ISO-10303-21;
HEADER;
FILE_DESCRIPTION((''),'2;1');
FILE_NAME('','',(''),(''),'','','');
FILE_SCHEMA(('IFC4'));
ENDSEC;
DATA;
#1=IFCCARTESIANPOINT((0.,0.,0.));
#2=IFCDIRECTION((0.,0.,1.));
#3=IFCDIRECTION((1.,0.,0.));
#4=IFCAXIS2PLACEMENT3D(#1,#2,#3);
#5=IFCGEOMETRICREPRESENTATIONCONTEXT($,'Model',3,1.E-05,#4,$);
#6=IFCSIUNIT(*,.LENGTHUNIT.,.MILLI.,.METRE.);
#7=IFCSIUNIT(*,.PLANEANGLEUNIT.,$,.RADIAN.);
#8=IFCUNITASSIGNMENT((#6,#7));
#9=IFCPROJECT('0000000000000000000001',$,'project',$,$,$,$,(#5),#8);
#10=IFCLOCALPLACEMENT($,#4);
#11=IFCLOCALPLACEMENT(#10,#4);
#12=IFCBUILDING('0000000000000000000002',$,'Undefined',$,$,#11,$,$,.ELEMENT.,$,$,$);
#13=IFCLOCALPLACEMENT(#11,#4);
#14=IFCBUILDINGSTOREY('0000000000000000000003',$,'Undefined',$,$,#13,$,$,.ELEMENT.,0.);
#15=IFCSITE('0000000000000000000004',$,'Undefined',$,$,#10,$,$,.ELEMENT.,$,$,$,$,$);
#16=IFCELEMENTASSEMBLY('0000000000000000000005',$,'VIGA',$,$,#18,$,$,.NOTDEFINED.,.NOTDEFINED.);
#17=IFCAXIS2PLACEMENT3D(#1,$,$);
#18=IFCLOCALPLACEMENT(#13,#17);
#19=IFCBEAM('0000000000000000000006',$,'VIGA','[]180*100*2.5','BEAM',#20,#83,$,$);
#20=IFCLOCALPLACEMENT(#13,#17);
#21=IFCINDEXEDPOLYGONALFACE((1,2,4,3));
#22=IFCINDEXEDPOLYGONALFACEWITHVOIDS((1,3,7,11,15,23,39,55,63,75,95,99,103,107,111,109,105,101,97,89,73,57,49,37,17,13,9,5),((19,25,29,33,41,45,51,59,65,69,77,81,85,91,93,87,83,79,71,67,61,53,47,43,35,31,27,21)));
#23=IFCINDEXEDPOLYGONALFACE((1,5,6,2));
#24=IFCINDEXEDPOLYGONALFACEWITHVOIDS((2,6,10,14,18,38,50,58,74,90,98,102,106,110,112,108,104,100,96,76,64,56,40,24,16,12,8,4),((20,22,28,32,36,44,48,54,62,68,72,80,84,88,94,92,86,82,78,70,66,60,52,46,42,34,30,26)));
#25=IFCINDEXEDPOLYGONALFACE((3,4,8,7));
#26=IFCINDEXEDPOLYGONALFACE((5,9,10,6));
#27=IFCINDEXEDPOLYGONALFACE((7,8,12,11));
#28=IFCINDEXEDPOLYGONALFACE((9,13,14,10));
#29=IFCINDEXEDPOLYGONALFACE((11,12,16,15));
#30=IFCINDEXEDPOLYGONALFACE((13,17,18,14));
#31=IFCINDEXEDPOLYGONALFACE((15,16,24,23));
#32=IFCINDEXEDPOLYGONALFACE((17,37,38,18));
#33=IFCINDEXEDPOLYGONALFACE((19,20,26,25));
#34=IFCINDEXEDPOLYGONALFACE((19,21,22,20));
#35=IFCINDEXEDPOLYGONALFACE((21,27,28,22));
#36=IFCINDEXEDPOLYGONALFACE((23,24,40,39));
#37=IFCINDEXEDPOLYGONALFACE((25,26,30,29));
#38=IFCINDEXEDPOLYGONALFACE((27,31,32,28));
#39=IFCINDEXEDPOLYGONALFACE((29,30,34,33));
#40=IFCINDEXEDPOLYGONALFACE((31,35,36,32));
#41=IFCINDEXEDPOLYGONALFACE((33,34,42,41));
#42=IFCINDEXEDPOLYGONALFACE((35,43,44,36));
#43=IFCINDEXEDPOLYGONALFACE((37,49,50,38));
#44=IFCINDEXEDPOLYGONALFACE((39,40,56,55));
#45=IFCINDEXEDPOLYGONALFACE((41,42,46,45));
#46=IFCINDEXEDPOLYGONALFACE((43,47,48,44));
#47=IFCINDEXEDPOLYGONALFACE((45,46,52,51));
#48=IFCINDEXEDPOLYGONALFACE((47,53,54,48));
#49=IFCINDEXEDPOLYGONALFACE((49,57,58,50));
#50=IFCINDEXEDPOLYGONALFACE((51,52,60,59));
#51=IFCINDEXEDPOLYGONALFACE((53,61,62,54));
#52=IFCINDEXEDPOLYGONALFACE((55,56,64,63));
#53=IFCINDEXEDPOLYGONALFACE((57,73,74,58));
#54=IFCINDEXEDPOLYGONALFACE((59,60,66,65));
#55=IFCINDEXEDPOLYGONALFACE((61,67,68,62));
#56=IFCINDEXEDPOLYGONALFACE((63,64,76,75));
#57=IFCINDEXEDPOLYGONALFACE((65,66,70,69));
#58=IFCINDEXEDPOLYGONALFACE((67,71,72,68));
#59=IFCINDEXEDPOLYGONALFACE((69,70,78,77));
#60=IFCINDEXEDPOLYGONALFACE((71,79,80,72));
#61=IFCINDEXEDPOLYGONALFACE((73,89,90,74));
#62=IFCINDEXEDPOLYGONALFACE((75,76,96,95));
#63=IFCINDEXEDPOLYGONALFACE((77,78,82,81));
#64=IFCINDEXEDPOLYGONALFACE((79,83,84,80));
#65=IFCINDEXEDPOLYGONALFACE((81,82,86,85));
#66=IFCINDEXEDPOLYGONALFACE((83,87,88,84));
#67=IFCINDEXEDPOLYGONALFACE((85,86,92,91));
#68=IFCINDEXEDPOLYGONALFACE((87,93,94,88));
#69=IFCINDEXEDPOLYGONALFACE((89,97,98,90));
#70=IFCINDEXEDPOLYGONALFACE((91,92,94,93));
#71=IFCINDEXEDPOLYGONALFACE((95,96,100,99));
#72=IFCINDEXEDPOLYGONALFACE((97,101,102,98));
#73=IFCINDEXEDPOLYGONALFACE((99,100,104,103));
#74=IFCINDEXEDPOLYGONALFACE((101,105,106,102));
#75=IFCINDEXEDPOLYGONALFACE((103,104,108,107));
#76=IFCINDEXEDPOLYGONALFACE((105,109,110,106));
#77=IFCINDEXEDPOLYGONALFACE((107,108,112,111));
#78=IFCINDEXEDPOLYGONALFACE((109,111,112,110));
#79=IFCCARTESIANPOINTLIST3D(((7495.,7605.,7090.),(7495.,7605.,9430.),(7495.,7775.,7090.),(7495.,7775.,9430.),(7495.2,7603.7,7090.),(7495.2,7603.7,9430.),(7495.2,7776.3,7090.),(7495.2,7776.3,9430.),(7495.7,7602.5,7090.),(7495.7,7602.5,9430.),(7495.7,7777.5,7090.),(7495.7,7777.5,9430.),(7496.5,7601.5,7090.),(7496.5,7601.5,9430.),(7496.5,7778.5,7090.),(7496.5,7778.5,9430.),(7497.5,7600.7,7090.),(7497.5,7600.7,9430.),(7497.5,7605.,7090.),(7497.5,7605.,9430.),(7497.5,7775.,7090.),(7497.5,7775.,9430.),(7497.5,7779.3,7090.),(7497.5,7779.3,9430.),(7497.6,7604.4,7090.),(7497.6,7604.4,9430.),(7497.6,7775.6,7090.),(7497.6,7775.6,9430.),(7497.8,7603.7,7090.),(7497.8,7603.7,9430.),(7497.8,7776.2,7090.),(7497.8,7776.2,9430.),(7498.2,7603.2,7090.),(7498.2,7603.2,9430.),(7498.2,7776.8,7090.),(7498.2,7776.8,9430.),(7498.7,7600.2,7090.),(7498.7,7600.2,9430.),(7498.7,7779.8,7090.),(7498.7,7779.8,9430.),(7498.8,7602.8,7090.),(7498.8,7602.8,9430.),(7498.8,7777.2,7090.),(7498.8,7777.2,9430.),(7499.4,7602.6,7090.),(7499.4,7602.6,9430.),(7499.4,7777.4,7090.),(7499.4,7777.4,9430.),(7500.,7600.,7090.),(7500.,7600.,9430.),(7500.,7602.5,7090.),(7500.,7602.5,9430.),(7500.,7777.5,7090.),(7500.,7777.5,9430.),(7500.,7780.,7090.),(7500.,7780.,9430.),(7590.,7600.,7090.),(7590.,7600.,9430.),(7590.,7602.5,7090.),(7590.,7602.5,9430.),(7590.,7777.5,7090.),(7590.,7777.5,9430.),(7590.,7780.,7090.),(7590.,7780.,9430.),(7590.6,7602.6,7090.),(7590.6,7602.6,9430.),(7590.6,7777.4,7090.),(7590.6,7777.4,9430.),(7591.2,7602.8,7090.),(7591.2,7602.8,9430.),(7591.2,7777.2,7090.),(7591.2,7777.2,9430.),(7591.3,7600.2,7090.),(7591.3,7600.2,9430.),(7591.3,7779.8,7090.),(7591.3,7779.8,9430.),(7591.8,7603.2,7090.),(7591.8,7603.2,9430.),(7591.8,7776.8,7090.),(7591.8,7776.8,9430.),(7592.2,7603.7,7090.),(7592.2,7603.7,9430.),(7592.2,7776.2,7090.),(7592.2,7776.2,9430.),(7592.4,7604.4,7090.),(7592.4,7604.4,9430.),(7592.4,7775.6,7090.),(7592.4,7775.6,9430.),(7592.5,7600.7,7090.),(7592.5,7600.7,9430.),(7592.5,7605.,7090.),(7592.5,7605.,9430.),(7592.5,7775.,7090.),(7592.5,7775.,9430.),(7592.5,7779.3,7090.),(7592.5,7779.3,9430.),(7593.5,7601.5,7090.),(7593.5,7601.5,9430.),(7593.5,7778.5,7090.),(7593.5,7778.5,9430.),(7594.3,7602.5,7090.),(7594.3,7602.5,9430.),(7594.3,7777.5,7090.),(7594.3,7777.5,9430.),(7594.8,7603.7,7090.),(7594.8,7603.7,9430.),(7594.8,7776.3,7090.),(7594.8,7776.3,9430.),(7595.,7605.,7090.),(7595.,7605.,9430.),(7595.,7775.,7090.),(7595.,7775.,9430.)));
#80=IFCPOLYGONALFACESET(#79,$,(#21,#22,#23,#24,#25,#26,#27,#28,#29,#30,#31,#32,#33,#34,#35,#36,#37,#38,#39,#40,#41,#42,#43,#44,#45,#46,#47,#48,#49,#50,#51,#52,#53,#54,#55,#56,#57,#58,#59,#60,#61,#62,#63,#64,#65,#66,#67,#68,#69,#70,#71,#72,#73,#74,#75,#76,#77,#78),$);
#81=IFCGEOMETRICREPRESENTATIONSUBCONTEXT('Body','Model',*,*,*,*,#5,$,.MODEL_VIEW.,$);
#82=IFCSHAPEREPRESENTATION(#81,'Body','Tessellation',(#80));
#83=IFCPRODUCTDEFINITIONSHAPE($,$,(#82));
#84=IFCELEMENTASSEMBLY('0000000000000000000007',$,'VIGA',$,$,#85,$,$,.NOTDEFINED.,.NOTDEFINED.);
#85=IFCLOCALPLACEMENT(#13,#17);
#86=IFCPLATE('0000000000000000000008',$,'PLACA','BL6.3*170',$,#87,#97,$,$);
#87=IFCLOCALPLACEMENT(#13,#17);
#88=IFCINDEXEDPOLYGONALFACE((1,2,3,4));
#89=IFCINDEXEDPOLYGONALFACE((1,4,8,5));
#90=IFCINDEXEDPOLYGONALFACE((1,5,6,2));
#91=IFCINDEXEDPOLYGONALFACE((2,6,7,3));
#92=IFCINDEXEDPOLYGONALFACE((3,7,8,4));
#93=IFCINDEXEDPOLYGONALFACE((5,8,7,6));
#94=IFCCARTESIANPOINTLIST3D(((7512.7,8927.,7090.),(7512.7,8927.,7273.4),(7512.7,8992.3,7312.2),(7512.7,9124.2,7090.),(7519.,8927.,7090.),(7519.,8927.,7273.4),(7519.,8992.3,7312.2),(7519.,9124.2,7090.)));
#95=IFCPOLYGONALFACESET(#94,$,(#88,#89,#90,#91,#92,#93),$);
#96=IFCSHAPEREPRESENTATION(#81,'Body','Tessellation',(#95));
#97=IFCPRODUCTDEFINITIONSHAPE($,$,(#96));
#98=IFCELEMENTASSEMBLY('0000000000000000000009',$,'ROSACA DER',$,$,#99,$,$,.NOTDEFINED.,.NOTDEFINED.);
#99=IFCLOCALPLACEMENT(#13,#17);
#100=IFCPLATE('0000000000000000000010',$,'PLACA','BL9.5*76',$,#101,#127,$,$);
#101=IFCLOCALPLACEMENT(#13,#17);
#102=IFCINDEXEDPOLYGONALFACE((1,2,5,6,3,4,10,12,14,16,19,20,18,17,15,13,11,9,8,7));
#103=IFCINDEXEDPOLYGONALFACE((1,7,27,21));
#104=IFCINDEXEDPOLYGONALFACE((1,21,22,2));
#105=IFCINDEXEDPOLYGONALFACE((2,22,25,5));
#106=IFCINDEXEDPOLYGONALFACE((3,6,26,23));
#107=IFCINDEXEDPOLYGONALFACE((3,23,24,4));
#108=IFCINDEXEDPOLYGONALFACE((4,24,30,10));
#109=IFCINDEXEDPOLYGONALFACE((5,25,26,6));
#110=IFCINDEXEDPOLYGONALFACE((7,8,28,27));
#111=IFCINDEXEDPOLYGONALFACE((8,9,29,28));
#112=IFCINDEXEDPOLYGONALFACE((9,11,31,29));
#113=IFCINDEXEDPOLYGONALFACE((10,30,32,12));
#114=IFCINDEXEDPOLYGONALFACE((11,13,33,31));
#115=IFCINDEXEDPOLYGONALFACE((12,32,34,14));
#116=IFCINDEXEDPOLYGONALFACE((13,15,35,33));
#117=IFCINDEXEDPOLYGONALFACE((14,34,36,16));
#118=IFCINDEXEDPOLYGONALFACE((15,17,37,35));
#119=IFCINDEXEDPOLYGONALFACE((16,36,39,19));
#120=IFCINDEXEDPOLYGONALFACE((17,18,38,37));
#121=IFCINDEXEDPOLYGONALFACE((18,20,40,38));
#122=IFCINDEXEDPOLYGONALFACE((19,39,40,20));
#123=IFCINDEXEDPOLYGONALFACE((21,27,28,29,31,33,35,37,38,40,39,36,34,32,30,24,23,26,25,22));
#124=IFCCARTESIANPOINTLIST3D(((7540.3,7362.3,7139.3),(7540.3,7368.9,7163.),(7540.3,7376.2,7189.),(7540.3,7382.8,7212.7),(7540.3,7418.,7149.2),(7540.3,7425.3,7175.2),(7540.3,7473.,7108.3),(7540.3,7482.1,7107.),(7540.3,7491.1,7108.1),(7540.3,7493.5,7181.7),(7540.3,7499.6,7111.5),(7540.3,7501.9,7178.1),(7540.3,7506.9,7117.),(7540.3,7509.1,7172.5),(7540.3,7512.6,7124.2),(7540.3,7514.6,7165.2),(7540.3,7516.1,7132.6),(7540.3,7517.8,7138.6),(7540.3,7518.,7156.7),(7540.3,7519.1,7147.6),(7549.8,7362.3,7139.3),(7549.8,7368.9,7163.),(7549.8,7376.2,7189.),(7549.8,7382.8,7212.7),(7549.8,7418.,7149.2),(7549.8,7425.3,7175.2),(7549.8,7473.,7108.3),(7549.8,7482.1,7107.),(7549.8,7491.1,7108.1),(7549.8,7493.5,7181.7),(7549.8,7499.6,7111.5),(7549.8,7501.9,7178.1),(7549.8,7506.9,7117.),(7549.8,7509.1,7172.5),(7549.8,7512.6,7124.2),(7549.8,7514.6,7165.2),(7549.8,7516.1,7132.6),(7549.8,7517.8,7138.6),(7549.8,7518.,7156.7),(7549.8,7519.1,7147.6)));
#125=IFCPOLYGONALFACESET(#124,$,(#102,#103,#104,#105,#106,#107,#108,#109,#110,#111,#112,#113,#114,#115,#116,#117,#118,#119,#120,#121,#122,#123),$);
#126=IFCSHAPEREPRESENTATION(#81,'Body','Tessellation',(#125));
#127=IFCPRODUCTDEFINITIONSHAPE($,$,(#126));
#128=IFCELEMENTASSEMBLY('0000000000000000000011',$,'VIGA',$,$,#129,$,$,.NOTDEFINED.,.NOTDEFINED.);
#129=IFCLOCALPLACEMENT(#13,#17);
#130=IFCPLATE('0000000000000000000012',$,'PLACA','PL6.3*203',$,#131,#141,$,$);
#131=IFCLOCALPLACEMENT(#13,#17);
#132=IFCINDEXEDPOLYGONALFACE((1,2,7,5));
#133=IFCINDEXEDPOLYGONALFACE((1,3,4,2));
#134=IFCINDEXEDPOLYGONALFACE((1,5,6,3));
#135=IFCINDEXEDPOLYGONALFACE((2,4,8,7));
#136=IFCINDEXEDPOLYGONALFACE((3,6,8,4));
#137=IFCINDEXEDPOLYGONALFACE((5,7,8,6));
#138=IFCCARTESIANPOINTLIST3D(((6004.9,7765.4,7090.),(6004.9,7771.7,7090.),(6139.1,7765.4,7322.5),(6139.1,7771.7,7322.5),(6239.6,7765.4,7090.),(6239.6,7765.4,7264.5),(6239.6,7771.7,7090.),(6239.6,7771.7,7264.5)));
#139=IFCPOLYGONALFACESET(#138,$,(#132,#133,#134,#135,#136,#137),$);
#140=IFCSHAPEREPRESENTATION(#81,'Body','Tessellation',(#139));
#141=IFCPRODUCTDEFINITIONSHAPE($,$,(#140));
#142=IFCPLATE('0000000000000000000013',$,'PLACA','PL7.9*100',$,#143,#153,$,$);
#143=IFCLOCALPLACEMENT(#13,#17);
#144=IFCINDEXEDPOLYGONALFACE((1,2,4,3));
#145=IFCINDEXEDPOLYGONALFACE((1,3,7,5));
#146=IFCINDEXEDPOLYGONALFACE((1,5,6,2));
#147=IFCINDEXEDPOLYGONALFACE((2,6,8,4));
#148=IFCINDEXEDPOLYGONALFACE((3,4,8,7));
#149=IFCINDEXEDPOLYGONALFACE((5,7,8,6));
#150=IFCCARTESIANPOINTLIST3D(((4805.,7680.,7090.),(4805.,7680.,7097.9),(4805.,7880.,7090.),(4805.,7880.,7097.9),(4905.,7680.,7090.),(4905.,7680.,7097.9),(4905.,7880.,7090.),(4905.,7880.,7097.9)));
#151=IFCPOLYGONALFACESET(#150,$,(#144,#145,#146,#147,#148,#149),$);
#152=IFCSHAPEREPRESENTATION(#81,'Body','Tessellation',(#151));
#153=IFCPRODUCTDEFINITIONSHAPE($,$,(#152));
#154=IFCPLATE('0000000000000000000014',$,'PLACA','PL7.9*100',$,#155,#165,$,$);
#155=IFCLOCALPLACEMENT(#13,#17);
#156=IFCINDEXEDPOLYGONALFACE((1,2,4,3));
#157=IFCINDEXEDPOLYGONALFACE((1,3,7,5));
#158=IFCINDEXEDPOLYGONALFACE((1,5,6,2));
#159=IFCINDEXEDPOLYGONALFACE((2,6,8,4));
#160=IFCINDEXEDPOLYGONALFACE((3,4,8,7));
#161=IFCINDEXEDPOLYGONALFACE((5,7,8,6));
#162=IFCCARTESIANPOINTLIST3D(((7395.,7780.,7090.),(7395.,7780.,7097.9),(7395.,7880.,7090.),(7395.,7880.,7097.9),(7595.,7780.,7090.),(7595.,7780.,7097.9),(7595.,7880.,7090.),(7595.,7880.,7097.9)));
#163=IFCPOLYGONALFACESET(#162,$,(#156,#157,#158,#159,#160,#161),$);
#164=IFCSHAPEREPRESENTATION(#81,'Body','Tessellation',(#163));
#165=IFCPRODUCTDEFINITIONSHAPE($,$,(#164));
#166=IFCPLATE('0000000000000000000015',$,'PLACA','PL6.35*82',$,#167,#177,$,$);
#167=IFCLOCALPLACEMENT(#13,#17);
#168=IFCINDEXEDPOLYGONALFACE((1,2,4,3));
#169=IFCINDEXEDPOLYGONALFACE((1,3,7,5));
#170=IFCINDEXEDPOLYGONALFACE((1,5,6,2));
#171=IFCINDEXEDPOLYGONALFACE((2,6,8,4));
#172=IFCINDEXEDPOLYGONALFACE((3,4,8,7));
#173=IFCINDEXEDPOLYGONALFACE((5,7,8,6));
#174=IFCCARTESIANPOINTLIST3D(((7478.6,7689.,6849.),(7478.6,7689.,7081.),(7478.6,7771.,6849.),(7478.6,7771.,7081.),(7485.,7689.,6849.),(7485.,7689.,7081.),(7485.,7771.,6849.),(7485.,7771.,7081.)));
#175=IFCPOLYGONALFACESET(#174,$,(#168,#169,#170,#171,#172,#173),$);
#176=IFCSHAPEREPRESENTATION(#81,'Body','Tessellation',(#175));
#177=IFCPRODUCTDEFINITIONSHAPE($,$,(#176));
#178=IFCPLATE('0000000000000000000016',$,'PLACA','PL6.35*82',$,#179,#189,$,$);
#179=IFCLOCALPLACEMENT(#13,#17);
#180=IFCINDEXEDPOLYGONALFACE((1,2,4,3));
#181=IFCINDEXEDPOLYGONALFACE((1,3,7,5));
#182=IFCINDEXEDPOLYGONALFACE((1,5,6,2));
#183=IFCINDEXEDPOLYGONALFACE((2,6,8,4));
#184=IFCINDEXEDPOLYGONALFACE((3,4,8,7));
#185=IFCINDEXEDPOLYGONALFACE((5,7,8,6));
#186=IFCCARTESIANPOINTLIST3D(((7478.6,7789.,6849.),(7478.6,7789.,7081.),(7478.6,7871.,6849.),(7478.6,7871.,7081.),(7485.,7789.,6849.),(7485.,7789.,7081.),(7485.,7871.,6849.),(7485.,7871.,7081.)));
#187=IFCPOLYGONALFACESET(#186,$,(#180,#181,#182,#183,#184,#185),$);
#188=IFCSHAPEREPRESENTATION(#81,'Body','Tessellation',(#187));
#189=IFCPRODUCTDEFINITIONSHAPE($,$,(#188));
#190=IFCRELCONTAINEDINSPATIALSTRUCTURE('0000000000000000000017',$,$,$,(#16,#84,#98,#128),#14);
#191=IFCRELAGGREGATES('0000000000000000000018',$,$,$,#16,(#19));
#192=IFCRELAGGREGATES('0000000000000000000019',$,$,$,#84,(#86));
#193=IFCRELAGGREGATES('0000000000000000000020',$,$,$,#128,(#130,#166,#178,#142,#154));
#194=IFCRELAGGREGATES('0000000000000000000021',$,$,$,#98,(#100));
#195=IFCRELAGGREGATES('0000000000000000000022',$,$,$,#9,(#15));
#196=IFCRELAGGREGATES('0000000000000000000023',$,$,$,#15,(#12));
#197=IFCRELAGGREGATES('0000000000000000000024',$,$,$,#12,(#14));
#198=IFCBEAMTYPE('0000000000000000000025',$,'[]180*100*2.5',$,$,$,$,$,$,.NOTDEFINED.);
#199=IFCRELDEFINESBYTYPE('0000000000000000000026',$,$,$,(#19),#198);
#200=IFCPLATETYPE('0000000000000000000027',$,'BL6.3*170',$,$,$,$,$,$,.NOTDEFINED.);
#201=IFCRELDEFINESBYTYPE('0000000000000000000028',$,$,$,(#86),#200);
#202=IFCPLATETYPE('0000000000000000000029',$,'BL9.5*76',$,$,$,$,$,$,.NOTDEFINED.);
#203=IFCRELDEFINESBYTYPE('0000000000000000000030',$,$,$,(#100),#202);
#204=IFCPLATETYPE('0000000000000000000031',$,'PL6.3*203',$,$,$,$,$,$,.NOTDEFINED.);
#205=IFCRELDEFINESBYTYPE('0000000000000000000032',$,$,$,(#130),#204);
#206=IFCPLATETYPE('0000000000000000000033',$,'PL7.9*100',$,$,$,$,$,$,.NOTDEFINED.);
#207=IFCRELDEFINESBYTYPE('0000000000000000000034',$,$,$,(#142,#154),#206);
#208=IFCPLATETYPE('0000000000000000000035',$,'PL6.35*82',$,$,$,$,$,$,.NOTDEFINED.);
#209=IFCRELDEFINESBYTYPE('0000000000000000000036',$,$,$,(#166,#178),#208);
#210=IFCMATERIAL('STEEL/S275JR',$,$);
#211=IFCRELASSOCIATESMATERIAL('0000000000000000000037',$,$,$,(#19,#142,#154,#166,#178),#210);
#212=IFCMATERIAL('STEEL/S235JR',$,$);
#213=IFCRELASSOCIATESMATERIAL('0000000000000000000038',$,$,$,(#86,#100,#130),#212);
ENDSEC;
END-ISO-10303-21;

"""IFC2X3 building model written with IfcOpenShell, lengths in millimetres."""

from ifc_helpers import new_model, si_unit, frame, frame_2d, origin_with_axes, origin_2d_with_axis, place, context, subcontext, project, spatial, polyline, circle_curve, parameter, trimmed, segment, composite_curve, rectangle, hollow_rectangle, outline, extrude, boolean, material, type_object, element, aggregate, save


model = new_model("IFC2X3")

# Units and contexts
model_context = context("Model", 3, precision=1e-05, world=origin_with_axes())
body_context = subcontext(model_context, "Body", "Model", "MODEL_VIEW")
ifc_project = project(units=[si_unit("LENGTHUNIT", "METRE", prefix="MILLI"), si_unit("PLANEANGLEUNIT", "RADIAN")], contexts=[model_context])

# Site, building, storey
site_placement = place(None, origin_with_axes())
site = spatial("IfcSite", under=ifc_project, at=site_placement, Name="Undefined", CompositionType="ELEMENT")
building_placement = place(site_placement, origin_with_axes())
building = spatial("IfcBuilding", under=site, at=building_placement, Name="Undefined", CompositionType="ELEMENT")
storey_placement = place(building_placement, origin_with_axes())
storey = spatial("IfcBuildingStorey", under=building, at=storey_placement, Name="Undefined", CompositionType="ELEMENT", Elevation=0.0)

# Element assembly, beam
ifc_material_1 = material(Name="STEEL/S275JR")
assembly_1_placement = place(storey_placement, origin_with_axes())
assembly_1 = element("IfcElementAssembly", 1, at=assembly_1_placement, inside=storey, Name="VIGA", AssemblyPlace="NOTDEFINED", PredefinedType="NOTDEFINED")
beam_type_1 = type_object("IfcBeamType", Name="[]180*100*2.5", PredefinedType="NOTDEFINED")
beam_1_placement = place(assembly_1_placement, frame((7545.0, 7690.0, 7090.0), z_axis=(0.0, 1.0, 0.0), x_axis=(0.0, 0.0, 1.0)))
beam_1 = element("IfcBeam", 2, at=beam_1_placement, type_object=beam_type_1, material=ifc_material_1, Name="VIGA", Description="[]180*100*2.5", ObjectType="BEAM", context=body_context, shape_type="SweptSolid", body=[
    extrude(hollow_rectangle(XDim=100.0, YDim=180.0, WallThickness=2.5, InnerFilletRadius=2.5, OuterFilletRadius=5.0, at=origin_2d_with_axis()), frame((2340.0, 0.0, 0.0), z_axis=(-1.0, 0.0, 0.0), x_axis=(0.0, -1.0, 0.0)), (0.0, 0.0, 1.0), 2340.0),
])
aggregate(assembly_1, [beam_1])

# Element assemblies, plates
assembly_2_placement = place(storey_placement, origin_with_axes())
assembly_2 = element("IfcElementAssembly", 3, at=assembly_2_placement, inside=storey, Name="VIGA", AssemblyPlace="NOTDEFINED", PredefinedType="NOTDEFINED")
ifc_material_2 = material(Name="STEEL/S235JR")
plate_type_1 = type_object("IfcPlateType", Name="BL6.3*170", PredefinedType="NOTDEFINED")
plate_1_placement = place(assembly_2_placement, frame((7515.9, 8927.0, 7090.0), z_axis=(1.0, 0.0, 0.0), x_axis=(0.0, 1.0, 0.0)))
plate_1 = element("IfcPlate", 4, at=plate_1_placement, type_object=plate_type_1, material=ifc_material_2, Name="PLACA", Description="BL6.3*170", context=body_context, shape_type="SweptSolid", body=[
    extrude(outline(polyline([(0.0, 0.0), (197.2, 0.0), (65.4, 222.2), (0.0, 183.4), (0.0, 0.0)])), frame((0.0, 0.0, -3.1), z_axis=(0.0, 0.0, 1.0), x_axis=(1.0, 0.0, 0.0)), (0.0, 0.0, 1.0), 6.3),
])
aggregate(assembly_2, [plate_1])
assembly_3_placement = place(storey_placement, origin_with_axes())
assembly_3 = element("IfcElementAssembly", 5, at=assembly_3_placement, inside=storey, Name="ROSACA DER", AssemblyPlace="NOTDEFINED", PredefinedType="NOTDEFINED")
plate_type_2 = type_object("IfcPlateType", Name="BL9.5*76", PredefinedType="NOTDEFINED")
plate_2_placement = place(assembly_3_placement, frame((7545.0, 7527.2, 7172.3), z_axis=(-1.0, 0.0, 0.0), x_axis=(0.0, -0.269246, -0.963072)))
plate_2 = element("IfcPlate", 6, at=plate_2_placement, type_object=plate_type_2, material=ifc_material_2, Name="PLACA", Description="BL9.5*76", context=body_context, shape_type="CSG", body=[
    boolean("DIFFERENCE", extrude(outline(composite_curve([segment(trimmed(circle_curve(frame_2d((35.0, 35.0), x_axis=(-1.0, 0.0)), 35.0), [parameter(0.0)], [parameter(1.570796)], True, "PARAMETER"), True, "CONTINUOUS"), segment(polyline([(35.0, 0.0), (41.2, 0.0)]), True, "CONTINUOUS"), segment(trimmed(circle_curve(frame_2d((41.2, 35.0), x_axis=(0.0, -1.0)), 35.0), [parameter(0.0)], [parameter(1.570796)], True, "PARAMETER"), True, "CONTINUOUS"), segment(polyline([(76.2, 35.0), (76.2, 150.0), (0.0, 150.0), (0.0, 35.0)]), True, "CONTINUOUS")], self_intersect=True)), frame((0.0, 0.0, -4.7), z_axis=(0.0, 0.0, 1.0), x_axis=(1.0, 0.0, 0.0)), (0.0, 0.0, 1.0), 9.5), extrude(rectangle(XDim=27.0, YDim=27.0, at=origin_2d_with_axis()), frame((38.1, 250.0, 0.0), z_axis=(0.0, -1.0, 0.0), x_axis=(0.0, 0.0, 1.0)), (0.0, 0.0, 1.0), 151.0)),
])

# Element assembly, plates
assembly_4_placement = place(storey_placement, origin_with_axes())
assembly_4 = element("IfcElementAssembly", 7, at=assembly_4_placement, inside=storey, Name="VIGA", AssemblyPlace="NOTDEFINED", PredefinedType="NOTDEFINED")
plate_type_3 = type_object("IfcPlateType", Name="PL6.3*203", PredefinedType="NOTDEFINED")
plate_3_placement = place(assembly_4_placement, frame((6004.9, 7768.6, 7090.0), z_axis=(0.0, -1.0, 0.0), x_axis=(1.0, 0.0, 0.0)))
plate_3 = element("IfcPlate", 8, at=plate_3_placement, type_object=plate_type_3, material=ifc_material_2, Name="PLACA", Description="PL6.3*203", context=body_context, shape_type="SweptSolid", body=[
    extrude(outline(polyline([(0.0, 0.0), (234.7, 0.0), (234.7, 174.5), (134.3, 232.5), (0.0, 0.0)])), frame((0.0, 0.0, -3.1), z_axis=(0.0, 0.0, 1.0), x_axis=(1.0, 0.0, 0.0)), (0.0, 0.0, 1.0), 6.3),
])
plate_type_4 = type_object("IfcPlateType", Name="PL7.9*100", PredefinedType="NOTDEFINED")
plate_4_placement = place(assembly_4_placement, frame((4905.0, 7880.0, 7093.9), z_axis=(0.0, 0.0, 1.0), x_axis=(-1.0, 0.0, 0.0)))
plate_4 = element("IfcPlate", 9, at=plate_4_placement, type_object=plate_type_4, material=ifc_material_1, Name="PLACA", Description="PL7.9*100", context=body_context, shape_type="SweptSolid", body=[
    extrude(outline(polyline([(0.0, 0.0), (100.0, 0.0), (100.0, 200.0), (0.0, 200.0), (0.0, 0.0)])), frame((0.0, 0.0, -4.0), z_axis=(0.0, 0.0, 1.0), x_axis=(1.0, 0.0, 0.0)), (0.0, 0.0, 1.0), 7.9),
])
plate_5_placement = place(assembly_4_placement, frame((7395.0, 7880.0, 7093.9), z_axis=(0.0, 0.0, 1.0), x_axis=(0.0, -1.0, 0.0)))
plate_5 = element("IfcPlate", 10, at=plate_5_placement, type_object=plate_type_4, material=ifc_material_1, Name="PLACA", Description="PL7.9*100", context=body_context, shape_type="SweptSolid", body=[
    extrude(outline(polyline([(0.0, 0.0), (100.0, 0.0), (100.0, 200.0), (0.0, 200.0), (0.0, 0.0)])), frame((0.0, 0.0, -4.0), z_axis=(0.0, 0.0, 1.0), x_axis=(1.0, 0.0, 0.0)), (0.0, 0.0, 1.0), 7.9),
])
plate_type_5 = type_object("IfcPlateType", Name="PL6.35*82", PredefinedType="NOTDEFINED")
plate_6_placement = place(assembly_4_placement, frame((7481.8, 7689.0, 7081.0), z_axis=(-1.0, 0.0, 0.0), x_axis=(0.0, 1.0, 0.0)))
plate_6 = element("IfcPlate", 11, at=plate_6_placement, type_object=plate_type_5, material=ifc_material_1, Name="PLACA", Description="PL6.35*82", context=body_context, shape_type="SweptSolid", body=[
    extrude(outline(polyline([(0.0, 0.0), (82.0, 0.0), (82.0, 232.0), (0.0, 232.0), (0.0, 0.0)])), frame((0.0, 0.0, -3.2), z_axis=(0.0, 0.0, 1.0), x_axis=(1.0, 0.0, 0.0)), (0.0, 0.0, 1.0), 6.4),
])
plate_7_placement = place(assembly_4_placement, frame((7481.8, 7789.0, 7081.0), z_axis=(-1.0, 0.0, 0.0), x_axis=(0.0, 1.0, 0.0)))
plate_7 = element("IfcPlate", 12, at=plate_7_placement, type_object=plate_type_5, material=ifc_material_1, Name="PLACA", Description="PL6.35*82", context=body_context, shape_type="SweptSolid", body=[
    extrude(outline(polyline([(0.0, 0.0), (82.0, 0.0), (82.0, 232.0), (0.0, 232.0), (0.0, 0.0)])), frame((0.0, 0.0, -3.2), z_axis=(0.0, 0.0, 1.0), x_axis=(1.0, 0.0, 0.0)), (0.0, 0.0, 1.0), 6.4),
])

aggregate(assembly_4, [plate_3, plate_6, plate_7, plate_4, plate_5])

aggregate(assembly_3, [plate_2])

save(model, "model.ifc")
